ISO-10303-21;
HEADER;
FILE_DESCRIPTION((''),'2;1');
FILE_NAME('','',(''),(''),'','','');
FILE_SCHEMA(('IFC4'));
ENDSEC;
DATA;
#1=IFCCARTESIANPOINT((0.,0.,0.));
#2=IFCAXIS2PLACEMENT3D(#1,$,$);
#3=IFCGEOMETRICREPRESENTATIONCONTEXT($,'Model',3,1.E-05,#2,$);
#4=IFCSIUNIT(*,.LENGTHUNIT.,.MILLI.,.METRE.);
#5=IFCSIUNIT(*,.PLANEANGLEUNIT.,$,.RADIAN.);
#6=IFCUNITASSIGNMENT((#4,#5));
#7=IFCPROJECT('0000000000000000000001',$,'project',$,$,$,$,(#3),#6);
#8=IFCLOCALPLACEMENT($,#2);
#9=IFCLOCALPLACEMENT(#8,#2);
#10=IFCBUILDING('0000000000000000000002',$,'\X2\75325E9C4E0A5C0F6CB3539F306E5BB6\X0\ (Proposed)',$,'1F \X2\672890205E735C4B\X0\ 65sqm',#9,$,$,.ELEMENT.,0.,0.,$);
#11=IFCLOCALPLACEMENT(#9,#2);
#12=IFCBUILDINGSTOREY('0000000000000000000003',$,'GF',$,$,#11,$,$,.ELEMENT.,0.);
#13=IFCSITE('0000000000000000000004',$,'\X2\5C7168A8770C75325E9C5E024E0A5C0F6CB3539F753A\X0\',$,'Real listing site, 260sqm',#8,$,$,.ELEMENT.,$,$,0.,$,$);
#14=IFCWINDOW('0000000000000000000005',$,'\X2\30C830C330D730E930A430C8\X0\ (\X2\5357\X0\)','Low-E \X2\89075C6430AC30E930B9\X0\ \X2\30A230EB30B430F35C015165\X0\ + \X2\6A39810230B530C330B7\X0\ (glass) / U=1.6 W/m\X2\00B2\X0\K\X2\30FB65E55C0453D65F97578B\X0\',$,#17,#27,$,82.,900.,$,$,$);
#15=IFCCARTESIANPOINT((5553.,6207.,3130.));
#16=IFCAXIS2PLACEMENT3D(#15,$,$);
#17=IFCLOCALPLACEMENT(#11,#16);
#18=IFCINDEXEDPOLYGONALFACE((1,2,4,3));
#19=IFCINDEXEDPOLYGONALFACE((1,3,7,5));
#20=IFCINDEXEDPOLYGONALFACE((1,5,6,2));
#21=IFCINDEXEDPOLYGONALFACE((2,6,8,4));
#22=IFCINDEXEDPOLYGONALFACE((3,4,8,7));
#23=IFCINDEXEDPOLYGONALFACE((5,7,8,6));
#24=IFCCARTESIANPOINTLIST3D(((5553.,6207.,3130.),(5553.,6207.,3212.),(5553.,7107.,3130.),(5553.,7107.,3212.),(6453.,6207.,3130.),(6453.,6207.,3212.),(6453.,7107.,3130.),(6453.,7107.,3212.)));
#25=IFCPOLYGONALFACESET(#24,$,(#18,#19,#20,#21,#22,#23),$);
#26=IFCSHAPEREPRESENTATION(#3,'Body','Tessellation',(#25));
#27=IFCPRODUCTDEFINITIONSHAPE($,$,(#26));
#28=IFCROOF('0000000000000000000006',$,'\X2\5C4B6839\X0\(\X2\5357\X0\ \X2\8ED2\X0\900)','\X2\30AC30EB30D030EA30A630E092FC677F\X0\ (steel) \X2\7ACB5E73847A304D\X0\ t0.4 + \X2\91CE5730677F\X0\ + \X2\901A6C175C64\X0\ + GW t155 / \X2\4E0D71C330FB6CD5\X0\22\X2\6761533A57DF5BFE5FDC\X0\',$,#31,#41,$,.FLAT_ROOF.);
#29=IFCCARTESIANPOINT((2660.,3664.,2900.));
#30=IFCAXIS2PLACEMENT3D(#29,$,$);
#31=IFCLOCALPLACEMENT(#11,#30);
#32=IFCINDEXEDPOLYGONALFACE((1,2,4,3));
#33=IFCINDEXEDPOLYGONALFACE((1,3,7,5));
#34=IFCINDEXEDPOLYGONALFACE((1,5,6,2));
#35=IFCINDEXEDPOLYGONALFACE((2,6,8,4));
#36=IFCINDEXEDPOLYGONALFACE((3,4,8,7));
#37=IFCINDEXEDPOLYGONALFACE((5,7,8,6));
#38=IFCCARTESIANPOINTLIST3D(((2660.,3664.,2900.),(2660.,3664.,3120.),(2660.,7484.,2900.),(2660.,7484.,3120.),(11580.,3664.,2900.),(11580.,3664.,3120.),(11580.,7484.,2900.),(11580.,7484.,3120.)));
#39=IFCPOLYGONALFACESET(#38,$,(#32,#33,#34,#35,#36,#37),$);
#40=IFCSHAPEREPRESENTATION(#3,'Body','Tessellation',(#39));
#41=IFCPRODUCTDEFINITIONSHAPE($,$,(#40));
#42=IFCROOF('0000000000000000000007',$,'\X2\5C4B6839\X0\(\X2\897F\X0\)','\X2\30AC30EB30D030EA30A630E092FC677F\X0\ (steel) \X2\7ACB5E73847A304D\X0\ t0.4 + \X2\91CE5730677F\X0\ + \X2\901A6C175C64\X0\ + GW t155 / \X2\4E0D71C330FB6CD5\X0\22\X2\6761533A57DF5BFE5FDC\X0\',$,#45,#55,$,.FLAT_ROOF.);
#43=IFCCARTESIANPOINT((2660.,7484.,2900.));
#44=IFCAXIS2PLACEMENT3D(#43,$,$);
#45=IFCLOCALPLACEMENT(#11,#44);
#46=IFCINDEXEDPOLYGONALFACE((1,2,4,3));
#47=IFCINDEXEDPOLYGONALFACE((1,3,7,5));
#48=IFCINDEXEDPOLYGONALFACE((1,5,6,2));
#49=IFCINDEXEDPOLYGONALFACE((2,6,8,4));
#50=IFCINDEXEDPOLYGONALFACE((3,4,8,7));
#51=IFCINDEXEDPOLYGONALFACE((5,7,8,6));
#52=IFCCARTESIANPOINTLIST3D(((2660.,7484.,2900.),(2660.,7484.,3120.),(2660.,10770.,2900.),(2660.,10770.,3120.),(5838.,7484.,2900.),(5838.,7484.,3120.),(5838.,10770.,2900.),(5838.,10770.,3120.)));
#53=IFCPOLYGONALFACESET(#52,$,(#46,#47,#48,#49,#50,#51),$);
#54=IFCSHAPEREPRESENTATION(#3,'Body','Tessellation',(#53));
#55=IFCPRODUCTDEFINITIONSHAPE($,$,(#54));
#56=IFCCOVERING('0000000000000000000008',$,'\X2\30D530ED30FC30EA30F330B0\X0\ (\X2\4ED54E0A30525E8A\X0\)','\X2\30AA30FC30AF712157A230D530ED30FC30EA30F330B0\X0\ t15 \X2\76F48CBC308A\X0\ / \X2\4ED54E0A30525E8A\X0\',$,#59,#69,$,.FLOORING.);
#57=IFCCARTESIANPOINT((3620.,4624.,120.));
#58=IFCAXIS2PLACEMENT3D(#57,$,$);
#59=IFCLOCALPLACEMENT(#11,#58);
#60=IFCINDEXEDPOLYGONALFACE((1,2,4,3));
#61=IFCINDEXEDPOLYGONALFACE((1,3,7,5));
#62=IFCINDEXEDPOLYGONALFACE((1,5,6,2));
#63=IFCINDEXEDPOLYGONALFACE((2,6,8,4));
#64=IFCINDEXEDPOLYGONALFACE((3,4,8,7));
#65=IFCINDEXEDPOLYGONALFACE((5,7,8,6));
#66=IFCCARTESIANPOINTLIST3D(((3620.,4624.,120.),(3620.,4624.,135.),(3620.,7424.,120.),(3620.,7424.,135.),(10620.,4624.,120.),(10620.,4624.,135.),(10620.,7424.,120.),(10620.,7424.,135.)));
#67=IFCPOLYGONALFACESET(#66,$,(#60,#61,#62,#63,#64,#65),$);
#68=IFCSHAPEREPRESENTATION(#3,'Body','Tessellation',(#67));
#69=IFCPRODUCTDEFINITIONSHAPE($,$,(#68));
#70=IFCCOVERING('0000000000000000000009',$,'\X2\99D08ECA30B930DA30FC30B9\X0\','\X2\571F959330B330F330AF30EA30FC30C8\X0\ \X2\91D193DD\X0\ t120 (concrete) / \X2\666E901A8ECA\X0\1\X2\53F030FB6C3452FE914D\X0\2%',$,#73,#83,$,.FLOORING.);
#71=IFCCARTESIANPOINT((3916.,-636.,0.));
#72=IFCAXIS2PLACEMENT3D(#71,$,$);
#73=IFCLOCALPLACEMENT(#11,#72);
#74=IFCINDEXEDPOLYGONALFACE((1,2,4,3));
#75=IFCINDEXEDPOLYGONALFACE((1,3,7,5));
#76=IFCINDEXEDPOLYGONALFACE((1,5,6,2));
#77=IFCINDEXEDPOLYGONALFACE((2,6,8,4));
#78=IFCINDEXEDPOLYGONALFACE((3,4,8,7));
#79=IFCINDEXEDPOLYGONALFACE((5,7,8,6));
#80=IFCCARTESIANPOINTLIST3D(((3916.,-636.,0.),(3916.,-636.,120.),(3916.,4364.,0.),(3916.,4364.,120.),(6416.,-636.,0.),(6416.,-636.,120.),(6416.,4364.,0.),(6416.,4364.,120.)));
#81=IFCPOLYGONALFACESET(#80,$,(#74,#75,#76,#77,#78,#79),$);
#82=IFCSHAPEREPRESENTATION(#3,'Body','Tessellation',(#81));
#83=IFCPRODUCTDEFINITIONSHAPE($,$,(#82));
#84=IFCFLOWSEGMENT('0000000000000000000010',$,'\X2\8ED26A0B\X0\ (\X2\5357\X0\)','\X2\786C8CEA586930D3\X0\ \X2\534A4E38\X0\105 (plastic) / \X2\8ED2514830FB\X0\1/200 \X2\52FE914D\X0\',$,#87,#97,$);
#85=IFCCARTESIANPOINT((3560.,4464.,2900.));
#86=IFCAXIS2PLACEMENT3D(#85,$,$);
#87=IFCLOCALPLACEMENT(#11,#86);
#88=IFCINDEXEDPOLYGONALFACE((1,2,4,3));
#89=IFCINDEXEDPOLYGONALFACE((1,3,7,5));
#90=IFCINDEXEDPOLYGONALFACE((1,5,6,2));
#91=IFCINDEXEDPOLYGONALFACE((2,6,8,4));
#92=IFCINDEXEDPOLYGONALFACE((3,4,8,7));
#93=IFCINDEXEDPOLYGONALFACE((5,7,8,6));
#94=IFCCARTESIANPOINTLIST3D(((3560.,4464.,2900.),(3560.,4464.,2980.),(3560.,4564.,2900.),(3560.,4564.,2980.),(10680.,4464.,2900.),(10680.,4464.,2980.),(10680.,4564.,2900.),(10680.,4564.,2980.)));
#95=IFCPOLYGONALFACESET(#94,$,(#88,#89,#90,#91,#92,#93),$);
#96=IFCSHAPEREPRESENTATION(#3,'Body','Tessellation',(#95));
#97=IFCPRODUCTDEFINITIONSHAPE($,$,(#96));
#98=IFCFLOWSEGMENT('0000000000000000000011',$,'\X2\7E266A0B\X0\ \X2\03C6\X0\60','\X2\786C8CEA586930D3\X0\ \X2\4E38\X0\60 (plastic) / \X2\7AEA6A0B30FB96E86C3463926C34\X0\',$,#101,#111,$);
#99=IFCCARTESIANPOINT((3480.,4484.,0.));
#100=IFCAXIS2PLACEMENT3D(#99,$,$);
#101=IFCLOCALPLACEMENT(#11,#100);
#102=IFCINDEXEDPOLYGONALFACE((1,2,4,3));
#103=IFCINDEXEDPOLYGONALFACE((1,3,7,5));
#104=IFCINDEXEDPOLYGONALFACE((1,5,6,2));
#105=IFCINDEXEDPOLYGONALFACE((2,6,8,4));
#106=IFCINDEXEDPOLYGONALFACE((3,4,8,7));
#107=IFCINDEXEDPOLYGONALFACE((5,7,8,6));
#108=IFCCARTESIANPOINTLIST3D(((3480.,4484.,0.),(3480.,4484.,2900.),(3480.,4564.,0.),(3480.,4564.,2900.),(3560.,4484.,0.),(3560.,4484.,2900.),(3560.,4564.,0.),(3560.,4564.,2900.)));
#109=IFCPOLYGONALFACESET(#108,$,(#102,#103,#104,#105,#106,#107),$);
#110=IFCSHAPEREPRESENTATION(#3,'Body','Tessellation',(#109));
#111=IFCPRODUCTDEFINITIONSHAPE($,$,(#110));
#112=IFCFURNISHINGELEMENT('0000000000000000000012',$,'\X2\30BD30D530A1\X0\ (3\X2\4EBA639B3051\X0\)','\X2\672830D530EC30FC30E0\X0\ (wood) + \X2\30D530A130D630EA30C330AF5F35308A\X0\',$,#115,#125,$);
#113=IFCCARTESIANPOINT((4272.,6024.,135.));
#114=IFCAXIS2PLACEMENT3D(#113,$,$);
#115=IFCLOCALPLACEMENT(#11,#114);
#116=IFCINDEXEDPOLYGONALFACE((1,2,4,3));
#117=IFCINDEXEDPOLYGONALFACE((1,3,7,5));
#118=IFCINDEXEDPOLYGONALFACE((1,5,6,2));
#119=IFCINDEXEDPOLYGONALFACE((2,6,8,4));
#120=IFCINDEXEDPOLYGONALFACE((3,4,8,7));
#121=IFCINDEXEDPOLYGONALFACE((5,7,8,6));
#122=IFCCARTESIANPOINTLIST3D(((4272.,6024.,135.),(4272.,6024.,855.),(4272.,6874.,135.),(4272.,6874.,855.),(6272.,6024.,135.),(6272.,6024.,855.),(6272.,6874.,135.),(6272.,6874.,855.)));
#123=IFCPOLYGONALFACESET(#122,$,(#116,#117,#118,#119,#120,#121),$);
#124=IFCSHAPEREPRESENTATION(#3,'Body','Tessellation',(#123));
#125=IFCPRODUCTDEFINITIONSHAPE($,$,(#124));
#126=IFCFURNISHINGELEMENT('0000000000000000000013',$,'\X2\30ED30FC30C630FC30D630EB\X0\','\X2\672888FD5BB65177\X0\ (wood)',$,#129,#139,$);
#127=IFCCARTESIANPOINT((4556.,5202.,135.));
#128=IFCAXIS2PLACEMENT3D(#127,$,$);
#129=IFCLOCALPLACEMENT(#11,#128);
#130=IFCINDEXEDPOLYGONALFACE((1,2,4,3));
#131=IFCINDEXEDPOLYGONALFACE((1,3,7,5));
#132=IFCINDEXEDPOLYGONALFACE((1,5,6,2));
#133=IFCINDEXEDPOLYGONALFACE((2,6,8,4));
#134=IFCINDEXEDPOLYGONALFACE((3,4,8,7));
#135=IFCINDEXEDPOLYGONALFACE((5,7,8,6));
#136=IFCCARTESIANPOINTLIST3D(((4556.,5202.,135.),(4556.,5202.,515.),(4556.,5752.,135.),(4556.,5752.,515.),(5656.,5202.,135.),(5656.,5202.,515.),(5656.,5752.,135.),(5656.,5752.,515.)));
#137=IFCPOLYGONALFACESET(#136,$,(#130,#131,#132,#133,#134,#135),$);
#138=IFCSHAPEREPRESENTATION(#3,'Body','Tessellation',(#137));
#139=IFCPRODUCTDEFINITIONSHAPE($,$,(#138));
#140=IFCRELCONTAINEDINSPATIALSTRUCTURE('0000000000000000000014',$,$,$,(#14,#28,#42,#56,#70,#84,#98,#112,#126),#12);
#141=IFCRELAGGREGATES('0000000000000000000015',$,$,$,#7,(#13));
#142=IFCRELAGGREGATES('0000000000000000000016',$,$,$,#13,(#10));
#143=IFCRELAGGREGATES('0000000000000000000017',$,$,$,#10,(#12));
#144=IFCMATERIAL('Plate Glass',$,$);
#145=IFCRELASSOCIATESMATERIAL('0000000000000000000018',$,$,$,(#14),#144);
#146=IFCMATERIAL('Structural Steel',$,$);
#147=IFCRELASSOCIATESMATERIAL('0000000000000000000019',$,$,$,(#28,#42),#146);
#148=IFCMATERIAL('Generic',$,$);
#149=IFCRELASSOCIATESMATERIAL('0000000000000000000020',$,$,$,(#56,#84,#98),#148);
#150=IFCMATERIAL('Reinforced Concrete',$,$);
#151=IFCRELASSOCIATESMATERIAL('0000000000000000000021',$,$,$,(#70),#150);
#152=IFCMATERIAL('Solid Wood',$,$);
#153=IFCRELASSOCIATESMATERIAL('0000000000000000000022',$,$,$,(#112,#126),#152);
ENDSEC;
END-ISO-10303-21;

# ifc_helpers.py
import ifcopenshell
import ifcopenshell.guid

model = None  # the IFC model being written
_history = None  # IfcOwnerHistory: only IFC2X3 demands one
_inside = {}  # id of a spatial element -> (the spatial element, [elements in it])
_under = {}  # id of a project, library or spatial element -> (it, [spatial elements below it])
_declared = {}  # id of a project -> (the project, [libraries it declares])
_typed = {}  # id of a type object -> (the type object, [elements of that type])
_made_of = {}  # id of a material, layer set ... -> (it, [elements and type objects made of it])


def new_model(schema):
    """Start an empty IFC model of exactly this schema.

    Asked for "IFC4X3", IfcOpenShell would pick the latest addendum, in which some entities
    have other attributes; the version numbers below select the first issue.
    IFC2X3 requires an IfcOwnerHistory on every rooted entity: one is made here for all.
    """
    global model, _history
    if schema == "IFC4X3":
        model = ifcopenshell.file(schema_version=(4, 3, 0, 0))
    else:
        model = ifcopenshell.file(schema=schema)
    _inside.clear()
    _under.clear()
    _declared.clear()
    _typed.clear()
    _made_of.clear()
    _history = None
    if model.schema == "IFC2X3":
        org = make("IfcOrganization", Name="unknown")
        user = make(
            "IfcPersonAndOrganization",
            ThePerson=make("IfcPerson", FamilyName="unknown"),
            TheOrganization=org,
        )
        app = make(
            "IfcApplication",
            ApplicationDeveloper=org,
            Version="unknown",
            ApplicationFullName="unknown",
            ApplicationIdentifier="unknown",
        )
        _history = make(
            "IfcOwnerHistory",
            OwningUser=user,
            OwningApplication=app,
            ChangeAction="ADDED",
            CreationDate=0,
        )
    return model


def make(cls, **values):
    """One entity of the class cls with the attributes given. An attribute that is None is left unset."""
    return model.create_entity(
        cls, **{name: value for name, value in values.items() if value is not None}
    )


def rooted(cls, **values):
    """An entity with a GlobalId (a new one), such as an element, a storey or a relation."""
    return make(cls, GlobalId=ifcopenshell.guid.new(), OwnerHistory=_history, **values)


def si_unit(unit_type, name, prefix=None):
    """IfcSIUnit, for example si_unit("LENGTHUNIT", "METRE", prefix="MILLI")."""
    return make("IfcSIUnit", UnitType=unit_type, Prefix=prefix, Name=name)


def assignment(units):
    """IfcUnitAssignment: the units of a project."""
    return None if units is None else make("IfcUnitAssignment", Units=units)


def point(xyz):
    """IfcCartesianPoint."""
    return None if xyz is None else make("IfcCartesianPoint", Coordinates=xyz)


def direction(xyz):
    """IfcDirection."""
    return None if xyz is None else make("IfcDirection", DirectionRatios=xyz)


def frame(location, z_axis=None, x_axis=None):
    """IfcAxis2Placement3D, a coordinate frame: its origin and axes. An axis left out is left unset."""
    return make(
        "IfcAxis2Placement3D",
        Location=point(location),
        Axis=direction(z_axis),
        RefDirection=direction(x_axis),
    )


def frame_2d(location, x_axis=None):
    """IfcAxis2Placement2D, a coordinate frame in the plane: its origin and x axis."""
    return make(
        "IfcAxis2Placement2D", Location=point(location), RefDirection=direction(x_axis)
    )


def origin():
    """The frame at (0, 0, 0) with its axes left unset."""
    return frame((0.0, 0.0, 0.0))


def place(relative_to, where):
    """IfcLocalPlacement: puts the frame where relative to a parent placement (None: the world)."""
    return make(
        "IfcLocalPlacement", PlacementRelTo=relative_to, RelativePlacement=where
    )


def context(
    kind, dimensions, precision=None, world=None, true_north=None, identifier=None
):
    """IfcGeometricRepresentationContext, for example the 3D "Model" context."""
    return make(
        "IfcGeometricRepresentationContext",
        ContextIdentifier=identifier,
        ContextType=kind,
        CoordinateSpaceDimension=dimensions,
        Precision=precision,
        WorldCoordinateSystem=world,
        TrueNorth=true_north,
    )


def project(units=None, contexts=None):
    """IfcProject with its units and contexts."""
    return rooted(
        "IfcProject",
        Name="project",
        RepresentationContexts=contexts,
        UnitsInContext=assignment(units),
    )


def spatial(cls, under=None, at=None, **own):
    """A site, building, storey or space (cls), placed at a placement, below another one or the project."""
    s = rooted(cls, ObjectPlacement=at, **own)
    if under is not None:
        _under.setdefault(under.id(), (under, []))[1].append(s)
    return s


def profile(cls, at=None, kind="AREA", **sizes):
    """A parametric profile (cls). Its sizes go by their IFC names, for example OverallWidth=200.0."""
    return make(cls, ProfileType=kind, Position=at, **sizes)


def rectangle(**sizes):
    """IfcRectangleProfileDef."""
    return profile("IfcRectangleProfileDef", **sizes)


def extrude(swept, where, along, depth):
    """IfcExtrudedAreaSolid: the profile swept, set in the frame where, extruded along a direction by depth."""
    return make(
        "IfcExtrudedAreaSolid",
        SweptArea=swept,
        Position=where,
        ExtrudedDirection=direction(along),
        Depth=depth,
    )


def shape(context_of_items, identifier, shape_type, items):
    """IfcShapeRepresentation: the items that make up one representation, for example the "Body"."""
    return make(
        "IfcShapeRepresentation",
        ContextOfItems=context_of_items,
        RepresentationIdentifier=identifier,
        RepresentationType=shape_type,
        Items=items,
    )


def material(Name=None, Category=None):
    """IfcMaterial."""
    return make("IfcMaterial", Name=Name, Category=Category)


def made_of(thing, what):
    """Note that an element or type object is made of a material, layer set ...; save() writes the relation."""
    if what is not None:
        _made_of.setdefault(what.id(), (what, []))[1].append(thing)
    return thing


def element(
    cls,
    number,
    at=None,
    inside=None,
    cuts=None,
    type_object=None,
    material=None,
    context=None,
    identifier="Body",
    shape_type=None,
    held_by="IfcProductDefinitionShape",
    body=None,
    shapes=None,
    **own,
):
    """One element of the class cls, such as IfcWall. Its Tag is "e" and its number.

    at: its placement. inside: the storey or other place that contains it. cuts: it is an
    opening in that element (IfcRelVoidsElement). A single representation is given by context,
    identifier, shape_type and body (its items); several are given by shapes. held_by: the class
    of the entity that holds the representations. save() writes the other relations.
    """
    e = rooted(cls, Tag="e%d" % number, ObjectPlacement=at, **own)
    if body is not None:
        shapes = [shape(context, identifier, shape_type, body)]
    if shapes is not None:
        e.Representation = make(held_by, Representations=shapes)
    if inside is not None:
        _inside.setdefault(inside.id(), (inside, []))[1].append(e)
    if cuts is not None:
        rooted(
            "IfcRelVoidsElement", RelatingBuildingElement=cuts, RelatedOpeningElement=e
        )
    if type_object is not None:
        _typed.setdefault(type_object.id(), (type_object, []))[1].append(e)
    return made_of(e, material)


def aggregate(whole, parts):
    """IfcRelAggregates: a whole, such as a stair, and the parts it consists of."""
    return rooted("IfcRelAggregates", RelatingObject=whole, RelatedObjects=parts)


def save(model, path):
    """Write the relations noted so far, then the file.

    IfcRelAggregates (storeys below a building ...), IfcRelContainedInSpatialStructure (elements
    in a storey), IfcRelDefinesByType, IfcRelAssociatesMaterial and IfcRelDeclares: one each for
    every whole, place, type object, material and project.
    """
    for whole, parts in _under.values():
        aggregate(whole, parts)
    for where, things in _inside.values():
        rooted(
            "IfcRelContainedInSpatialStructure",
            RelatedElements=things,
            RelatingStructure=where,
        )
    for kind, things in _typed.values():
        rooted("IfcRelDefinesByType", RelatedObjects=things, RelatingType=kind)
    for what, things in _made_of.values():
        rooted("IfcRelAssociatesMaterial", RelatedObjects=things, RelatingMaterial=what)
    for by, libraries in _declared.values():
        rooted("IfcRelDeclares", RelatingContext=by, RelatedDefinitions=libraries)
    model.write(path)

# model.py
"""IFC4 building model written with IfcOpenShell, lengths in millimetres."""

from ifc_helpers import new_model, si_unit, frame, frame_2d, origin, place, context, project, spatial, rectangle, extrude, material, element, save


model = new_model("IFC4")

# Units and contexts
model_context = context("Model", 3, precision=1e-05, world=origin())
ifc_project = project(units=[si_unit("LENGTHUNIT", "METRE", prefix="MILLI"), si_unit("PLANEANGLEUNIT", "RADIAN")], contexts=[model_context])

# Site, building, storey
site_placement = place(None, origin())
site = spatial("IfcSite", under=ifc_project, at=site_placement, Name="山梨県甲府市上小河原町", ObjectType="Real listing site, 260sqm", CompositionType="ELEMENT", RefElevation=0.0)
building_placement = place(site_placement, origin())
building = spatial("IfcBuilding", under=site, at=building_placement, Name="甲府上小河原の家 (Proposed)", ObjectType="1F 木造平屋 65sqm", CompositionType="ELEMENT", ElevationOfRefHeight=0.0, ElevationOfTerrain=0.0)
storey_placement = place(building_placement, origin())
storey = spatial("IfcBuildingStorey", under=building, at=storey_placement, Name="GF", CompositionType="ELEMENT", Elevation=0.0)

# Shared definitions
ifc_material_1 = material(Name="Solid Wood")

# Shared definitions
ifc_material_2 = material(Name="Reinforced Concrete")

# Shared definitions
ifc_material_3 = material(Name="Plate Glass")

# Window
window_1_placement = place(storey_placement, frame((5553.0, 6207.0, 3130.0)))
element("IfcWindow", 1, at=window_1_placement, inside=storey, material=ifc_material_3, Name="トップライト (南)", Description="Low-E 複層ガラス アルゴン封入 + 樹脂サッシ (glass) / U=1.6 W/m²K・日射取得型", OverallHeight=82.0, OverallWidth=900.0, context=model_context, shape_type="SweptSolid", body=[
    extrude(rectangle(XDim=900.0, YDim=900.0, at=frame_2d((450.0, 450.0))), frame((5553.0, 6207.0, 3130.0)), (0.0, 0.0, 1.0), 82.0),
])

# Roofs
ifc_material_4 = material(Name="Structural Steel")
roof_1_placement = place(storey_placement, frame((2660.0, 3664.0, 2900.0)))
element("IfcRoof", 2, at=roof_1_placement, inside=storey, material=ifc_material_4, Name="屋根(南 軒900)", Description="ガルバリウム鋼板 (steel) 立平葺き t0.4 + 野地板 + 通気層 + GW t155 / 不燃・法22条区域対応", PredefinedType="FLAT_ROOF", context=model_context, shape_type="SweptSolid", body=[
    extrude(rectangle(XDim=8920.0, YDim=3820.0, at=frame_2d((4460.0, 1910.0))), frame((2660.0, 3664.0, 2900.0)), (0.0, 0.0, 1.0), 220.0),
])
roof_2_placement = place(storey_placement, frame((2660.0, 7484.0, 2900.0)))
element("IfcRoof", 3, at=roof_2_placement, inside=storey, material=ifc_material_4, Name="屋根(西)", Description="ガルバリウム鋼板 (steel) 立平葺き t0.4 + 野地板 + 通気層 + GW t155 / 不燃・法22条区域対応", PredefinedType="FLAT_ROOF", context=model_context, shape_type="SweptSolid", body=[
    extrude(rectangle(XDim=3178.0, YDim=3286.0, at=frame_2d((1589.0, 1643.0))), frame((2660.0, 7484.0, 2900.0)), (0.0, 0.0, 1.0), 220.0),
])

# Coverings
ifc_material_5 = material(Name="Generic")
covering_1_placement = place(storey_placement, frame((3620.0, 4624.0, 120.0)))
element("IfcCovering", 4, at=covering_1_placement, inside=storey, material=ifc_material_5, Name="フローリング (仕上げ床)", Description="オーク無垢フローリング t15 直貼り / 仕上げ床", PredefinedType="FLOORING", context=model_context, shape_type="SweptSolid", body=[
    extrude(rectangle(XDim=7000.0, YDim=2800.0, at=frame_2d((3500.0, 1400.0))), frame((3620.0, 4624.0, 120.0)), (0.0, 0.0, 1.0), 15.0),
])
covering_2_placement = place(storey_placement, frame((3916.0, -636.0, 0.0)))
element("IfcCovering", 5, at=covering_2_placement, inside=storey, material=ifc_material_2, Name="駐車スペース", Description="土間コンクリート 金鏝 t120 (concrete) / 普通車1台・水勾配2%", PredefinedType="FLOORING", context=model_context, shape_type="SweptSolid", body=[
    extrude(rectangle(XDim=2500.0, YDim=5000.0, at=frame_2d((1250.0, 2500.0))), frame((3916.0, -636.0, 0.0)), (0.0, 0.0, 1.0), 120.0),
])

# Flow segments
flow_segment_1_placement = place(storey_placement, frame((3560.0, 4464.0, 2900.0)))
element("IfcFlowSegment", 6, at=flow_segment_1_placement, inside=storey, material=ifc_material_5, Name="軒樋 (南)", Description="硬質塩ビ 半丸105 (plastic) / 軒先・1/200 勾配", context=model_context, shape_type="SweptSolid", body=[
    extrude(rectangle(XDim=7120.0, YDim=100.0, at=frame_2d((3560.0, 50.0))), frame((3560.0, 4464.0, 2900.0)), (0.0, 0.0, 1.0), 80.0),
])
flow_segment_2_placement = place(storey_placement, frame((3480.0, 4484.0, 0.0)))
element("IfcFlowSegment", 7, at=flow_segment_2_placement, inside=storey, material=ifc_material_5, Name="縦樋 φ60", Description="硬質塩ビ 丸60 (plastic) / 竪樋・雨水排水", context=model_context, shape_type="SweptSolid", body=[
    extrude(rectangle(XDim=80.0, YDim=80.0, at=frame_2d((40.0, 40.0))), frame((3480.0, 4484.0, 0.0)), (0.0, 0.0, 1.0), 2900.0),
])

# Furnishing elements
furnishing_1_placement = place(storey_placement, frame((4272.0, 6024.0, 135.0)))
element("IfcFurnishingElement", 8, at=furnishing_1_placement, inside=storey, material=ifc_material_1, Name="ソファ (3人掛け)", Description="木フレーム (wood) + ファブリック張り", context=model_context, shape_type="SweptSolid", body=[
    extrude(rectangle(XDim=2000.0, YDim=850.0, at=frame_2d((1000.0, 425.0))), frame((4272.0, 6024.0, 135.0)), (0.0, 0.0, 1.0), 720.0),
])
furnishing_2_placement = place(storey_placement, frame((4556.0, 5202.0, 135.0)))
element("IfcFurnishingElement", 9, at=furnishing_2_placement, inside=storey, material=ifc_material_1, Name="ローテーブル", Description="木製家具 (wood)", context=model_context, shape_type="SweptSolid", body=[
    extrude(rectangle(XDim=1100.0, YDim=550.0, at=frame_2d((550.0, 275.0))), frame((4556.0, 5202.0, 135.0)), (0.0, 0.0, 1.0), 380.0),
])

save(model, "model.ifc")
